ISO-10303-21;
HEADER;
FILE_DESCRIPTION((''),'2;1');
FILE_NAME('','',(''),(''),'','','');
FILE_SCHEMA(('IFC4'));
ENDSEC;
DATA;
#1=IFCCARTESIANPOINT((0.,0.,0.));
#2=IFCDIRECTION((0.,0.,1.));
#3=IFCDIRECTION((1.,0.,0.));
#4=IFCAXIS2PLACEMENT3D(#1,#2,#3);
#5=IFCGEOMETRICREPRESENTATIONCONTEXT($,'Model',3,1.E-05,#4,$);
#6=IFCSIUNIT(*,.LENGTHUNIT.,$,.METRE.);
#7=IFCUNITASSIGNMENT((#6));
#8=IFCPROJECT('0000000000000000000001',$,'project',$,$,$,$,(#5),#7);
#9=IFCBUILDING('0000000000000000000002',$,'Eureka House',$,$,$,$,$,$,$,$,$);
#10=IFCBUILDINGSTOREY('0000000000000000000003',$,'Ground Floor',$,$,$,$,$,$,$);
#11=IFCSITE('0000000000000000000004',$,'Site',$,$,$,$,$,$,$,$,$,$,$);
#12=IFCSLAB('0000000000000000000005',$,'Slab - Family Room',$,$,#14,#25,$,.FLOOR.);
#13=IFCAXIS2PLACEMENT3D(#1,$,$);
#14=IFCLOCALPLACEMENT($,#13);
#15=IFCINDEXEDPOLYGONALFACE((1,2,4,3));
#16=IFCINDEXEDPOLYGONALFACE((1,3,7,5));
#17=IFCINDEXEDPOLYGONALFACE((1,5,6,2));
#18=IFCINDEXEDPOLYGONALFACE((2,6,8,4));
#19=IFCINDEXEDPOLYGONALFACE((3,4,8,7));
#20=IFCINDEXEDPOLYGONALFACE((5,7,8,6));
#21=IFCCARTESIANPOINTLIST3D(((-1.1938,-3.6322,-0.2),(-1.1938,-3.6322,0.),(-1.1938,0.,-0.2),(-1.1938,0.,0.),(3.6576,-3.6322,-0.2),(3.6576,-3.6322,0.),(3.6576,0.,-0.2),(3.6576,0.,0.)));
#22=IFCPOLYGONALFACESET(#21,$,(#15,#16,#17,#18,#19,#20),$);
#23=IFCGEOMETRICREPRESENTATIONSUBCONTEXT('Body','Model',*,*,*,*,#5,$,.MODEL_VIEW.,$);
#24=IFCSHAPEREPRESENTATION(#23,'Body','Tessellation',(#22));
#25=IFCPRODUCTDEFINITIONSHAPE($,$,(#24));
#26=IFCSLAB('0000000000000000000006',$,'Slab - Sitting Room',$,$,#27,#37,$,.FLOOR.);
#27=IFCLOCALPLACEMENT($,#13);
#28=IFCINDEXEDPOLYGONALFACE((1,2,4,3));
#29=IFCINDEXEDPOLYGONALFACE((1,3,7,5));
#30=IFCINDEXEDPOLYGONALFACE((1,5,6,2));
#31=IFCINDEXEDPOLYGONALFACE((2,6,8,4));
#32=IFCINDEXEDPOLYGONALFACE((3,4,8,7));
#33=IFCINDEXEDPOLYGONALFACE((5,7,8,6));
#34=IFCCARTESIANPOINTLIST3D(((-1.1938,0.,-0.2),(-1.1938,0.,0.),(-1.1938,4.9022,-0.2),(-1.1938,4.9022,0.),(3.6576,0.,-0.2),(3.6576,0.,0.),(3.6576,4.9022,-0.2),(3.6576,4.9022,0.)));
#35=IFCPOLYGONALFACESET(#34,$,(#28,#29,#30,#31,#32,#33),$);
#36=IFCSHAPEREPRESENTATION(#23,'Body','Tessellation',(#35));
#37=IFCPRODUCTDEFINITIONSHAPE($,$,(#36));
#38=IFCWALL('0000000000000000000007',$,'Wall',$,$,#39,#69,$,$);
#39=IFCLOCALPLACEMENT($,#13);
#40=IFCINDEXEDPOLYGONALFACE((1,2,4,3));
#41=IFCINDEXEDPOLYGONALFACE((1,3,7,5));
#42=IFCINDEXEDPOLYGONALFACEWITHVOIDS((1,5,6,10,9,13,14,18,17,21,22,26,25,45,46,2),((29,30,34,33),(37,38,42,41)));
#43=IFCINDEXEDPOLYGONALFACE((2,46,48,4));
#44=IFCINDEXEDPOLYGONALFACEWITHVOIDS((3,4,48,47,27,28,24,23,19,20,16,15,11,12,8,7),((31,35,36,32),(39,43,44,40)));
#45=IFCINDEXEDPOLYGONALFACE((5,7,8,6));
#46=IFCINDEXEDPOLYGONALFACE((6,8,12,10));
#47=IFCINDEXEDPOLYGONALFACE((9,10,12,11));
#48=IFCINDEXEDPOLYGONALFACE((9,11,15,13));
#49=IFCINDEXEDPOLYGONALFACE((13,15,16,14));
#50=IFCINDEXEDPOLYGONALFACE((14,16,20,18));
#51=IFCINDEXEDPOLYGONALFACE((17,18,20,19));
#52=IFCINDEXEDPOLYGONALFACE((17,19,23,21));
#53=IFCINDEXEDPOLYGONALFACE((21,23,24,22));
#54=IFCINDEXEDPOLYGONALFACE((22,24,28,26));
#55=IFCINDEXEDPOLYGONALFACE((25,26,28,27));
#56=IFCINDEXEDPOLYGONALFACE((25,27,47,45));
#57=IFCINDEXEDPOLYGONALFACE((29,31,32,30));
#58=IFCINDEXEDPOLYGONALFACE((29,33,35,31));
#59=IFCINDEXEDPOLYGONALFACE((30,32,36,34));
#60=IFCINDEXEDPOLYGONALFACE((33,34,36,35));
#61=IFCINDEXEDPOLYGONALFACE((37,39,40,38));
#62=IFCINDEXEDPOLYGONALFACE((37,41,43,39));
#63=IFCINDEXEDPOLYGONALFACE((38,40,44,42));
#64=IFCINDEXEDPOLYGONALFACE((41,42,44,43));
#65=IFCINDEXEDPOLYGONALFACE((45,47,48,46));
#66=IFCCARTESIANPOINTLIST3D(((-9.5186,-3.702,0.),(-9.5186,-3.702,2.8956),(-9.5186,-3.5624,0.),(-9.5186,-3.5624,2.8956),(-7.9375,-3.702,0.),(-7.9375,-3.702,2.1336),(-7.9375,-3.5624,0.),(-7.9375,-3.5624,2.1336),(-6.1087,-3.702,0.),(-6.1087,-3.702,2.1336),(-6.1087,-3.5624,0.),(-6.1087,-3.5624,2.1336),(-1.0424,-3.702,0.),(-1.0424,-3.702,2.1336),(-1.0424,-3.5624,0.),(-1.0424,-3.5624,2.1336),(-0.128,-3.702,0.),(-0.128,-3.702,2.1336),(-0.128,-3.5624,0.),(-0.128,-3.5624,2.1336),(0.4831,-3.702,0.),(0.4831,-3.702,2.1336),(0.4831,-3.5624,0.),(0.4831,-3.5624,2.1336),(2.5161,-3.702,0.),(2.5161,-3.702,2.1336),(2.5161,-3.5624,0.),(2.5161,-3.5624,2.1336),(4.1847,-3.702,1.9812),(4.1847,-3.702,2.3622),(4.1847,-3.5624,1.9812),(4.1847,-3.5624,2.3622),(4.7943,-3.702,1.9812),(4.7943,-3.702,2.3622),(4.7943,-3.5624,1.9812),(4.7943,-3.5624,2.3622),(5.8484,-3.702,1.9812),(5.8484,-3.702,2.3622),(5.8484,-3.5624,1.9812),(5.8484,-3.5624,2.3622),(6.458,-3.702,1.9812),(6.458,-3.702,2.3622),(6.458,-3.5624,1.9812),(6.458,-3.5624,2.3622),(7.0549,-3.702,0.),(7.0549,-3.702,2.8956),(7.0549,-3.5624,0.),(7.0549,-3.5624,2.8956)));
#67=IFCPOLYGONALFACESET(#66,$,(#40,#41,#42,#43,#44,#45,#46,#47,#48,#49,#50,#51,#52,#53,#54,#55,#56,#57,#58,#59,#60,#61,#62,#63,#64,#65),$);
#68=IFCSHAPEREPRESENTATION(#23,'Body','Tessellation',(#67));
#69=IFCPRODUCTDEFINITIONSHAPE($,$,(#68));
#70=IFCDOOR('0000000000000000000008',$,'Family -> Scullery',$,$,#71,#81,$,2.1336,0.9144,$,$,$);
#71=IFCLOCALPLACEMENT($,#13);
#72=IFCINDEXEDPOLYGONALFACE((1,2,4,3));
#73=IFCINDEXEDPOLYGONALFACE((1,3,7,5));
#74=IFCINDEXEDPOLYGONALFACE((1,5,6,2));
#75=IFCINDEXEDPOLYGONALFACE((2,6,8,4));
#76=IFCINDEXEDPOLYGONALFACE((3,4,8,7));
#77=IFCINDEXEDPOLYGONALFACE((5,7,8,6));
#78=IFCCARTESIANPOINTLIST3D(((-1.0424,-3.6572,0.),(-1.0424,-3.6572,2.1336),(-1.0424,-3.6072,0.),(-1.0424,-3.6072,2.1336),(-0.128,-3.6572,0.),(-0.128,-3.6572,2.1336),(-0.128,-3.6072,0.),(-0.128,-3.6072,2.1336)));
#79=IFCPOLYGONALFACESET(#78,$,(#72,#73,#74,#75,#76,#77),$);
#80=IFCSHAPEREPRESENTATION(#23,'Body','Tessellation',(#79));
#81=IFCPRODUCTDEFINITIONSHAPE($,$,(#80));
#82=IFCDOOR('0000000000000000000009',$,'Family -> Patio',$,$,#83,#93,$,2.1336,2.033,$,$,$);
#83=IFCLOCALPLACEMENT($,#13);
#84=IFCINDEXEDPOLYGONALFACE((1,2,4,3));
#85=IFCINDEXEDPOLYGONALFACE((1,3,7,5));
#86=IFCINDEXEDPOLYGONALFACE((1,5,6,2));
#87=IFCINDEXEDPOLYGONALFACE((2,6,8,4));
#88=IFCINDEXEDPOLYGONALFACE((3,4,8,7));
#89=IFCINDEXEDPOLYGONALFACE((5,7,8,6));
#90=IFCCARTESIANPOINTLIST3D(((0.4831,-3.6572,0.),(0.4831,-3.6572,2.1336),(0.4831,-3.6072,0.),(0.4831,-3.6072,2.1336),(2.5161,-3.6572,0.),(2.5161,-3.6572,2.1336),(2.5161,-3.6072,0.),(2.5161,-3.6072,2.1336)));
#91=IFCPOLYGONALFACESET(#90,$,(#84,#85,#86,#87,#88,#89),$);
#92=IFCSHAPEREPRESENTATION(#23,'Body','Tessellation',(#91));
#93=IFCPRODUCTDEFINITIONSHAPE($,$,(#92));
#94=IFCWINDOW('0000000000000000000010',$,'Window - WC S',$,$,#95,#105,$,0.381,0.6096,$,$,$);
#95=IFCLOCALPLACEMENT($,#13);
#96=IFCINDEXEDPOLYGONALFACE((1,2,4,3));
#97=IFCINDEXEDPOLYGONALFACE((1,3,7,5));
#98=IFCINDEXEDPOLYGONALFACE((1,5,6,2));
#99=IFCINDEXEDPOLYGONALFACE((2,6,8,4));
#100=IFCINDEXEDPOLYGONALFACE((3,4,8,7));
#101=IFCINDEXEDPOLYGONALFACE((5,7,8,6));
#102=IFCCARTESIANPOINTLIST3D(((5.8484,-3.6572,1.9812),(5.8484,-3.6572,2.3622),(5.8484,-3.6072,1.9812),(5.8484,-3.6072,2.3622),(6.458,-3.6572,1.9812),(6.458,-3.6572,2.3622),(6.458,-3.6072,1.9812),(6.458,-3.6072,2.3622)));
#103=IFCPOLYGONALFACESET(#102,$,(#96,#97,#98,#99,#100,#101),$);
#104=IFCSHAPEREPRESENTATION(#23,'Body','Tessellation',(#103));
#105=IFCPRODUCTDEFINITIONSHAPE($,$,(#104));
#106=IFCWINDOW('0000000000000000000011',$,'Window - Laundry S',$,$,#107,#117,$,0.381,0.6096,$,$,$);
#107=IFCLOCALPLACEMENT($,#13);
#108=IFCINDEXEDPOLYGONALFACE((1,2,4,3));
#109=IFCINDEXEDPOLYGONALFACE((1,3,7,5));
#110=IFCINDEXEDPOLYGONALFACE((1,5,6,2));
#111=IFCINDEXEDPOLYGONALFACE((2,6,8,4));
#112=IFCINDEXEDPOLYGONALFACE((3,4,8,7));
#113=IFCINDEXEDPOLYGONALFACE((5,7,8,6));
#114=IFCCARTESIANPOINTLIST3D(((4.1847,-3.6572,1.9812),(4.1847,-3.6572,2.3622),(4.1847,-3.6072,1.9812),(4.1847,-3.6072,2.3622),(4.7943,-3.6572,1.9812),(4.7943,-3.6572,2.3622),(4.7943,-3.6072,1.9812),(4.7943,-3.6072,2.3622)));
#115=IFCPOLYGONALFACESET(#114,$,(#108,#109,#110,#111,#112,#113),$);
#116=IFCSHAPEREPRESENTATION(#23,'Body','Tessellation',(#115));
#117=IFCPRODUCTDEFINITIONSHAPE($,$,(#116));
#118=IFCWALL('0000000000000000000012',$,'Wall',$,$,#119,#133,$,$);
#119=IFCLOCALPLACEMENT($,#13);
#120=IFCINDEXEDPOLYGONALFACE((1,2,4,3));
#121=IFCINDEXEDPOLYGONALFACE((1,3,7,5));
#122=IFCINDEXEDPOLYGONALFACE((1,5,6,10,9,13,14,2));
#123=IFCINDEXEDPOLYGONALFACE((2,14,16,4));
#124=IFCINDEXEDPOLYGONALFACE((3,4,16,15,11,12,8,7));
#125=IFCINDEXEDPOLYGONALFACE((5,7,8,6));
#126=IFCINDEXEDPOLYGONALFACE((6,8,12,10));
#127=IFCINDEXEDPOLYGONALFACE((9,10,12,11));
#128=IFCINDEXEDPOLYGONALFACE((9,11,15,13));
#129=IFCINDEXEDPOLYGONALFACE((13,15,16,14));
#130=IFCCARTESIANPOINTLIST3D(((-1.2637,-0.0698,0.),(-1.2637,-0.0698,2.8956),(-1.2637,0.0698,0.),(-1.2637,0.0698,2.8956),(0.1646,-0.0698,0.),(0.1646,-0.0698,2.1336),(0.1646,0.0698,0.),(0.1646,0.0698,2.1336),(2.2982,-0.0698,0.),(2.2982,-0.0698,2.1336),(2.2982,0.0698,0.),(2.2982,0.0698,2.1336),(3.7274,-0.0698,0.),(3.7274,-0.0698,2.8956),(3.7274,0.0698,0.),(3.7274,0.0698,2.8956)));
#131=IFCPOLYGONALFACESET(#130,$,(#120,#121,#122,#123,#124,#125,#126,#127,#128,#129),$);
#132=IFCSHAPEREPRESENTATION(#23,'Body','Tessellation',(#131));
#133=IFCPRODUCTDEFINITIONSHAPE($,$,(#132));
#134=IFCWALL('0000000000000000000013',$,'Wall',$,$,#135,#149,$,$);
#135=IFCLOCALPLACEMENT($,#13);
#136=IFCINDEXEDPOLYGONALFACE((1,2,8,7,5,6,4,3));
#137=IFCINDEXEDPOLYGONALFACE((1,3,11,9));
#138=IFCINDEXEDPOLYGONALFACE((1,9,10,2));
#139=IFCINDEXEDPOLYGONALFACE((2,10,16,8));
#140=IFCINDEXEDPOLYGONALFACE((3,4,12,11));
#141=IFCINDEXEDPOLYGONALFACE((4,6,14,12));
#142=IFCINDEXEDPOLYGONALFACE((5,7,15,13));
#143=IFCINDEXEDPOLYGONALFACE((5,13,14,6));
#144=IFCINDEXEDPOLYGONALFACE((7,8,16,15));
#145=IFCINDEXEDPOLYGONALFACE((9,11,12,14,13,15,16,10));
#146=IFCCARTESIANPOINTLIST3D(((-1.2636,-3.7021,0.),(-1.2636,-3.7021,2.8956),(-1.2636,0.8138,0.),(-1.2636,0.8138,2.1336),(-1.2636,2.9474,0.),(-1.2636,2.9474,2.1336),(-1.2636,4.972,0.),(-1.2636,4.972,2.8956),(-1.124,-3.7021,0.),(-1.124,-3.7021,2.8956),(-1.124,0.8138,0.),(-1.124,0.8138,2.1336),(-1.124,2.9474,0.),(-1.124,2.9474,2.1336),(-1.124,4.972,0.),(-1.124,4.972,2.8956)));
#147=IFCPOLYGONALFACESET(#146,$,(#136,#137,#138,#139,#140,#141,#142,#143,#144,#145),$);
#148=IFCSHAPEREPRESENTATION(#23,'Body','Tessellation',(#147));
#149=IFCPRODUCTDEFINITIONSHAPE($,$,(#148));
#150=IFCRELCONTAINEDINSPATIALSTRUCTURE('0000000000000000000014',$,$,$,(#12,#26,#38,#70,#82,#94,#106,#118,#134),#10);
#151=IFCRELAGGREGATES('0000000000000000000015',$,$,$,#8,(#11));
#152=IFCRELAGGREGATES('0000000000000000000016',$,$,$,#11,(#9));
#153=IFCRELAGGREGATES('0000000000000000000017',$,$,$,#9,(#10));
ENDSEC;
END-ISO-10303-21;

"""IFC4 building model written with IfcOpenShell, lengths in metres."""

from ifc_helpers import new_model, si_unit, frame, origin, origin_with_axes, origin_2d, place, context, subcontext, project, spatial, rectangle, extrude, element, fill, save


model = new_model("IFC4")

# Units and contexts
model_context = context("Model", 3, precision=1e-05, world=origin_with_axes())
body_context = subcontext(model_context, "Body", "Model", "MODEL_VIEW")
ifc_project = project(units=[si_unit("LENGTHUNIT", "METRE")], contexts=[model_context])

# Site, building, storey
site = spatial("IfcSite", under=ifc_project, Name="Site")
building = spatial("IfcBuilding", under=site, Name="Eureka House")
storey = spatial("IfcBuildingStorey", under=building, Name="Ground Floor")

# Slabs
slab_1_placement = place(None, frame((1.2319, -1.8161, -0.2), z_axis=(0.0, 0.0, 1.0), x_axis=(1.0, 0.0, 0.0)))
element("IfcSlab", 1, at=slab_1_placement, inside=storey, Name="Slab - Family Room", PredefinedType="FLOOR", context=body_context, shape_type="SweptSolid", body=[
    extrude(rectangle(XDim=4.8514, YDim=3.6322, at=origin_2d()), origin(), (0.0, 0.0, 1.0), 0.2),
])
slab_2_placement = place(None, frame((1.2319, 2.4511, -0.2), z_axis=(0.0, 0.0, 1.0), x_axis=(1.0, 0.0, 0.0)))
element("IfcSlab", 2, at=slab_2_placement, inside=storey, Name="Slab - Sitting Room", PredefinedType="FLOOR", context=body_context, shape_type="SweptSolid", body=[
    extrude(rectangle(XDim=4.8514, YDim=4.9022, at=origin_2d()), origin(), (0.0, 0.0, 1.0), 0.2),
])

# Wall, openings, doors, windows
wall_1_placement = place(None, frame((-1.2319, -3.6322, 0.0), z_axis=(0.0, 0.0, 1.0), x_axis=(1.0, 0.0, 0.0)))
wall_1 = element("IfcWall", 3, at=wall_1_placement, inside=storey, Name="Wall", context=body_context, shape_type="SweptSolid", body=[
    extrude(rectangle(XDim=16.5735, YDim=0.1397, at=origin_2d()), origin(), (0.0, 0.0, 1.0), 2.8956),
])
opening_1_placement = place(wall_1_placement, frame((0.6467, 0.0, 0.0), z_axis=(0.0, 0.0, 1.0), x_axis=(1.0, 0.0, 0.0)))
opening_1 = element("IfcOpeningElement", 4, at=opening_1_placement, cuts=wall_1, context=body_context, shape_type="SweptSolid", body=[
    extrude(rectangle(XDim=0.9144, YDim=0.2397, at=origin_2d()), origin(), (0.0, 0.0, 1.0), 2.1336),
])
opening_2_placement = place(wall_1_placement, frame((2.7315, 0.0, 0.0), z_axis=(0.0, 0.0, 1.0), x_axis=(1.0, 0.0, 0.0)))
opening_2 = element("IfcOpeningElement", 5, at=opening_2_placement, cuts=wall_1, context=body_context, shape_type="SweptSolid", body=[
    extrude(rectangle(XDim=2.033, YDim=0.2397, at=origin_2d()), origin(), (0.0, 0.0, 1.0), 2.1336),
])
opening_3_placement = place(wall_1_placement, frame((-5.7912, 0.0, 0.0), z_axis=(0.0, 0.0, 1.0), x_axis=(1.0, 0.0, 0.0)))
element("IfcOpeningElement", 6, at=opening_3_placement, cuts=wall_1, context=body_context, shape_type="SweptSolid", body=[
    extrude(rectangle(XDim=1.8288, YDim=0.2397, at=origin_2d()), origin(), (0.0, 0.0, 1.0), 2.1336),
])
opening_4_placement = place(wall_1_placement, frame((7.385, 0.0, 1.9812), z_axis=(0.0, 0.0, 1.0), x_axis=(1.0, 0.0, 0.0)))
opening_4 = element("IfcOpeningElement", 7, at=opening_4_placement, cuts=wall_1, context=body_context, shape_type="SweptSolid", body=[
    extrude(rectangle(XDim=0.6096, YDim=0.2397, at=origin_2d()), origin(), (0.0, 0.0, 1.0), 0.381),
])
opening_5_placement = place(wall_1_placement, frame((5.7214, 0.0, 1.9812), z_axis=(0.0, 0.0, 1.0), x_axis=(1.0, 0.0, 0.0)))
opening_5 = element("IfcOpeningElement", 8, at=opening_5_placement, cuts=wall_1, context=body_context, shape_type="SweptSolid", body=[
    extrude(rectangle(XDim=0.6096, YDim=0.2397, at=origin_2d()), origin(), (0.0, 0.0, 1.0), 0.381),
])
door_1_placement = place(opening_1_placement, origin_with_axes())
door_1 = element("IfcDoor", 9, at=door_1_placement, inside=storey, Name="Family -> Scullery", OverallHeight=2.1336, OverallWidth=0.9144, context=body_context, shape_type="SweptSolid", body=[
    extrude(rectangle(XDim=0.9144, YDim=0.05, at=origin_2d()), origin(), (0.0, 0.0, 1.0), 2.1336),
])
fill(opening_1, door_1)
door_2_placement = place(opening_2_placement, origin_with_axes())
door_2 = element("IfcDoor", 10, at=door_2_placement, inside=storey, Name="Family -> Patio", OverallHeight=2.1336, OverallWidth=2.033, context=body_context, shape_type="SweptSolid", body=[
    extrude(rectangle(XDim=2.033, YDim=0.05, at=origin_2d()), origin(), (0.0, 0.0, 1.0), 2.1336),
])
fill(opening_2, door_2)
window_1_placement = place(opening_4_placement, origin_with_axes())
window_1 = element("IfcWindow", 11, at=window_1_placement, inside=storey, Name="Window - WC S", OverallHeight=0.381, OverallWidth=0.6096, context=body_context, shape_type="SweptSolid", body=[
    extrude(rectangle(XDim=0.6096, YDim=0.05, at=origin_2d()), origin(), (0.0, 0.0, 1.0), 0.381),
])
fill(opening_4, window_1)
window_2_placement = place(opening_5_placement, origin_with_axes())
window_2 = element("IfcWindow", 12, at=window_2_placement, inside=storey, Name="Window - Laundry S", OverallHeight=0.381, OverallWidth=0.6096, context=body_context, shape_type="SweptSolid", body=[
    extrude(rectangle(XDim=0.6096, YDim=0.05, at=origin_2d()), origin(), (0.0, 0.0, 1.0), 0.381),
])
fill(opening_5, window_2)

# Walls, openings
wall_2_placement = place(None, frame((1.2319, 0.0, 0.0), z_axis=(0.0, 0.0, 1.0), x_axis=(1.0, 0.0, 0.0)))
wall_2 = element("IfcWall", 13, at=wall_2_placement, inside=storey, Name="Wall", context=body_context, shape_type="SweptSolid", body=[
    extrude(rectangle(XDim=4.9911, YDim=0.1397, at=origin_2d()), origin(), (0.0, 0.0, 1.0), 2.8956),
])
opening_6_placement = place(wall_2_placement, frame((-0.0005, 0.0, 0.0), z_axis=(0.0, 0.0, 1.0), x_axis=(1.0, 0.0, 0.0)))
element("IfcOpeningElement", 14, at=opening_6_placement, cuts=wall_2, context=body_context, shape_type="SweptSolid", body=[
    extrude(rectangle(XDim=2.1336, YDim=0.2397, at=origin_2d()), origin(), (0.0, 0.0, 1.0), 2.1336),
])
wall_3_placement = place(None, frame((-1.1938, 0.635, 0.0), z_axis=(0.0, 0.0, 1.0), x_axis=(1.0, 0.0, 0.0)))
wall_3 = element("IfcWall", 15, at=wall_3_placement, inside=storey, Name="Wall", context=body_context, shape_type="SweptSolid", body=[
    extrude(rectangle(XDim=0.1397, YDim=8.6741, at=origin_2d()), origin(), (0.0, 0.0, 1.0), 2.8956),
])
opening_7_placement = place(wall_3_placement, frame((0.0, 1.2456, 0.0), z_axis=(0.0, 0.0, 1.0), x_axis=(1.0, 0.0, 0.0)))
element("IfcOpeningElement", 16, at=opening_7_placement, cuts=wall_3, context=body_context, shape_type="SweptSolid", body=[
    extrude(rectangle(XDim=0.2397, YDim=2.1336, at=origin_2d()), origin(), (0.0, 0.0, 1.0), 2.1336),
])

save(model, "model.ifc")
